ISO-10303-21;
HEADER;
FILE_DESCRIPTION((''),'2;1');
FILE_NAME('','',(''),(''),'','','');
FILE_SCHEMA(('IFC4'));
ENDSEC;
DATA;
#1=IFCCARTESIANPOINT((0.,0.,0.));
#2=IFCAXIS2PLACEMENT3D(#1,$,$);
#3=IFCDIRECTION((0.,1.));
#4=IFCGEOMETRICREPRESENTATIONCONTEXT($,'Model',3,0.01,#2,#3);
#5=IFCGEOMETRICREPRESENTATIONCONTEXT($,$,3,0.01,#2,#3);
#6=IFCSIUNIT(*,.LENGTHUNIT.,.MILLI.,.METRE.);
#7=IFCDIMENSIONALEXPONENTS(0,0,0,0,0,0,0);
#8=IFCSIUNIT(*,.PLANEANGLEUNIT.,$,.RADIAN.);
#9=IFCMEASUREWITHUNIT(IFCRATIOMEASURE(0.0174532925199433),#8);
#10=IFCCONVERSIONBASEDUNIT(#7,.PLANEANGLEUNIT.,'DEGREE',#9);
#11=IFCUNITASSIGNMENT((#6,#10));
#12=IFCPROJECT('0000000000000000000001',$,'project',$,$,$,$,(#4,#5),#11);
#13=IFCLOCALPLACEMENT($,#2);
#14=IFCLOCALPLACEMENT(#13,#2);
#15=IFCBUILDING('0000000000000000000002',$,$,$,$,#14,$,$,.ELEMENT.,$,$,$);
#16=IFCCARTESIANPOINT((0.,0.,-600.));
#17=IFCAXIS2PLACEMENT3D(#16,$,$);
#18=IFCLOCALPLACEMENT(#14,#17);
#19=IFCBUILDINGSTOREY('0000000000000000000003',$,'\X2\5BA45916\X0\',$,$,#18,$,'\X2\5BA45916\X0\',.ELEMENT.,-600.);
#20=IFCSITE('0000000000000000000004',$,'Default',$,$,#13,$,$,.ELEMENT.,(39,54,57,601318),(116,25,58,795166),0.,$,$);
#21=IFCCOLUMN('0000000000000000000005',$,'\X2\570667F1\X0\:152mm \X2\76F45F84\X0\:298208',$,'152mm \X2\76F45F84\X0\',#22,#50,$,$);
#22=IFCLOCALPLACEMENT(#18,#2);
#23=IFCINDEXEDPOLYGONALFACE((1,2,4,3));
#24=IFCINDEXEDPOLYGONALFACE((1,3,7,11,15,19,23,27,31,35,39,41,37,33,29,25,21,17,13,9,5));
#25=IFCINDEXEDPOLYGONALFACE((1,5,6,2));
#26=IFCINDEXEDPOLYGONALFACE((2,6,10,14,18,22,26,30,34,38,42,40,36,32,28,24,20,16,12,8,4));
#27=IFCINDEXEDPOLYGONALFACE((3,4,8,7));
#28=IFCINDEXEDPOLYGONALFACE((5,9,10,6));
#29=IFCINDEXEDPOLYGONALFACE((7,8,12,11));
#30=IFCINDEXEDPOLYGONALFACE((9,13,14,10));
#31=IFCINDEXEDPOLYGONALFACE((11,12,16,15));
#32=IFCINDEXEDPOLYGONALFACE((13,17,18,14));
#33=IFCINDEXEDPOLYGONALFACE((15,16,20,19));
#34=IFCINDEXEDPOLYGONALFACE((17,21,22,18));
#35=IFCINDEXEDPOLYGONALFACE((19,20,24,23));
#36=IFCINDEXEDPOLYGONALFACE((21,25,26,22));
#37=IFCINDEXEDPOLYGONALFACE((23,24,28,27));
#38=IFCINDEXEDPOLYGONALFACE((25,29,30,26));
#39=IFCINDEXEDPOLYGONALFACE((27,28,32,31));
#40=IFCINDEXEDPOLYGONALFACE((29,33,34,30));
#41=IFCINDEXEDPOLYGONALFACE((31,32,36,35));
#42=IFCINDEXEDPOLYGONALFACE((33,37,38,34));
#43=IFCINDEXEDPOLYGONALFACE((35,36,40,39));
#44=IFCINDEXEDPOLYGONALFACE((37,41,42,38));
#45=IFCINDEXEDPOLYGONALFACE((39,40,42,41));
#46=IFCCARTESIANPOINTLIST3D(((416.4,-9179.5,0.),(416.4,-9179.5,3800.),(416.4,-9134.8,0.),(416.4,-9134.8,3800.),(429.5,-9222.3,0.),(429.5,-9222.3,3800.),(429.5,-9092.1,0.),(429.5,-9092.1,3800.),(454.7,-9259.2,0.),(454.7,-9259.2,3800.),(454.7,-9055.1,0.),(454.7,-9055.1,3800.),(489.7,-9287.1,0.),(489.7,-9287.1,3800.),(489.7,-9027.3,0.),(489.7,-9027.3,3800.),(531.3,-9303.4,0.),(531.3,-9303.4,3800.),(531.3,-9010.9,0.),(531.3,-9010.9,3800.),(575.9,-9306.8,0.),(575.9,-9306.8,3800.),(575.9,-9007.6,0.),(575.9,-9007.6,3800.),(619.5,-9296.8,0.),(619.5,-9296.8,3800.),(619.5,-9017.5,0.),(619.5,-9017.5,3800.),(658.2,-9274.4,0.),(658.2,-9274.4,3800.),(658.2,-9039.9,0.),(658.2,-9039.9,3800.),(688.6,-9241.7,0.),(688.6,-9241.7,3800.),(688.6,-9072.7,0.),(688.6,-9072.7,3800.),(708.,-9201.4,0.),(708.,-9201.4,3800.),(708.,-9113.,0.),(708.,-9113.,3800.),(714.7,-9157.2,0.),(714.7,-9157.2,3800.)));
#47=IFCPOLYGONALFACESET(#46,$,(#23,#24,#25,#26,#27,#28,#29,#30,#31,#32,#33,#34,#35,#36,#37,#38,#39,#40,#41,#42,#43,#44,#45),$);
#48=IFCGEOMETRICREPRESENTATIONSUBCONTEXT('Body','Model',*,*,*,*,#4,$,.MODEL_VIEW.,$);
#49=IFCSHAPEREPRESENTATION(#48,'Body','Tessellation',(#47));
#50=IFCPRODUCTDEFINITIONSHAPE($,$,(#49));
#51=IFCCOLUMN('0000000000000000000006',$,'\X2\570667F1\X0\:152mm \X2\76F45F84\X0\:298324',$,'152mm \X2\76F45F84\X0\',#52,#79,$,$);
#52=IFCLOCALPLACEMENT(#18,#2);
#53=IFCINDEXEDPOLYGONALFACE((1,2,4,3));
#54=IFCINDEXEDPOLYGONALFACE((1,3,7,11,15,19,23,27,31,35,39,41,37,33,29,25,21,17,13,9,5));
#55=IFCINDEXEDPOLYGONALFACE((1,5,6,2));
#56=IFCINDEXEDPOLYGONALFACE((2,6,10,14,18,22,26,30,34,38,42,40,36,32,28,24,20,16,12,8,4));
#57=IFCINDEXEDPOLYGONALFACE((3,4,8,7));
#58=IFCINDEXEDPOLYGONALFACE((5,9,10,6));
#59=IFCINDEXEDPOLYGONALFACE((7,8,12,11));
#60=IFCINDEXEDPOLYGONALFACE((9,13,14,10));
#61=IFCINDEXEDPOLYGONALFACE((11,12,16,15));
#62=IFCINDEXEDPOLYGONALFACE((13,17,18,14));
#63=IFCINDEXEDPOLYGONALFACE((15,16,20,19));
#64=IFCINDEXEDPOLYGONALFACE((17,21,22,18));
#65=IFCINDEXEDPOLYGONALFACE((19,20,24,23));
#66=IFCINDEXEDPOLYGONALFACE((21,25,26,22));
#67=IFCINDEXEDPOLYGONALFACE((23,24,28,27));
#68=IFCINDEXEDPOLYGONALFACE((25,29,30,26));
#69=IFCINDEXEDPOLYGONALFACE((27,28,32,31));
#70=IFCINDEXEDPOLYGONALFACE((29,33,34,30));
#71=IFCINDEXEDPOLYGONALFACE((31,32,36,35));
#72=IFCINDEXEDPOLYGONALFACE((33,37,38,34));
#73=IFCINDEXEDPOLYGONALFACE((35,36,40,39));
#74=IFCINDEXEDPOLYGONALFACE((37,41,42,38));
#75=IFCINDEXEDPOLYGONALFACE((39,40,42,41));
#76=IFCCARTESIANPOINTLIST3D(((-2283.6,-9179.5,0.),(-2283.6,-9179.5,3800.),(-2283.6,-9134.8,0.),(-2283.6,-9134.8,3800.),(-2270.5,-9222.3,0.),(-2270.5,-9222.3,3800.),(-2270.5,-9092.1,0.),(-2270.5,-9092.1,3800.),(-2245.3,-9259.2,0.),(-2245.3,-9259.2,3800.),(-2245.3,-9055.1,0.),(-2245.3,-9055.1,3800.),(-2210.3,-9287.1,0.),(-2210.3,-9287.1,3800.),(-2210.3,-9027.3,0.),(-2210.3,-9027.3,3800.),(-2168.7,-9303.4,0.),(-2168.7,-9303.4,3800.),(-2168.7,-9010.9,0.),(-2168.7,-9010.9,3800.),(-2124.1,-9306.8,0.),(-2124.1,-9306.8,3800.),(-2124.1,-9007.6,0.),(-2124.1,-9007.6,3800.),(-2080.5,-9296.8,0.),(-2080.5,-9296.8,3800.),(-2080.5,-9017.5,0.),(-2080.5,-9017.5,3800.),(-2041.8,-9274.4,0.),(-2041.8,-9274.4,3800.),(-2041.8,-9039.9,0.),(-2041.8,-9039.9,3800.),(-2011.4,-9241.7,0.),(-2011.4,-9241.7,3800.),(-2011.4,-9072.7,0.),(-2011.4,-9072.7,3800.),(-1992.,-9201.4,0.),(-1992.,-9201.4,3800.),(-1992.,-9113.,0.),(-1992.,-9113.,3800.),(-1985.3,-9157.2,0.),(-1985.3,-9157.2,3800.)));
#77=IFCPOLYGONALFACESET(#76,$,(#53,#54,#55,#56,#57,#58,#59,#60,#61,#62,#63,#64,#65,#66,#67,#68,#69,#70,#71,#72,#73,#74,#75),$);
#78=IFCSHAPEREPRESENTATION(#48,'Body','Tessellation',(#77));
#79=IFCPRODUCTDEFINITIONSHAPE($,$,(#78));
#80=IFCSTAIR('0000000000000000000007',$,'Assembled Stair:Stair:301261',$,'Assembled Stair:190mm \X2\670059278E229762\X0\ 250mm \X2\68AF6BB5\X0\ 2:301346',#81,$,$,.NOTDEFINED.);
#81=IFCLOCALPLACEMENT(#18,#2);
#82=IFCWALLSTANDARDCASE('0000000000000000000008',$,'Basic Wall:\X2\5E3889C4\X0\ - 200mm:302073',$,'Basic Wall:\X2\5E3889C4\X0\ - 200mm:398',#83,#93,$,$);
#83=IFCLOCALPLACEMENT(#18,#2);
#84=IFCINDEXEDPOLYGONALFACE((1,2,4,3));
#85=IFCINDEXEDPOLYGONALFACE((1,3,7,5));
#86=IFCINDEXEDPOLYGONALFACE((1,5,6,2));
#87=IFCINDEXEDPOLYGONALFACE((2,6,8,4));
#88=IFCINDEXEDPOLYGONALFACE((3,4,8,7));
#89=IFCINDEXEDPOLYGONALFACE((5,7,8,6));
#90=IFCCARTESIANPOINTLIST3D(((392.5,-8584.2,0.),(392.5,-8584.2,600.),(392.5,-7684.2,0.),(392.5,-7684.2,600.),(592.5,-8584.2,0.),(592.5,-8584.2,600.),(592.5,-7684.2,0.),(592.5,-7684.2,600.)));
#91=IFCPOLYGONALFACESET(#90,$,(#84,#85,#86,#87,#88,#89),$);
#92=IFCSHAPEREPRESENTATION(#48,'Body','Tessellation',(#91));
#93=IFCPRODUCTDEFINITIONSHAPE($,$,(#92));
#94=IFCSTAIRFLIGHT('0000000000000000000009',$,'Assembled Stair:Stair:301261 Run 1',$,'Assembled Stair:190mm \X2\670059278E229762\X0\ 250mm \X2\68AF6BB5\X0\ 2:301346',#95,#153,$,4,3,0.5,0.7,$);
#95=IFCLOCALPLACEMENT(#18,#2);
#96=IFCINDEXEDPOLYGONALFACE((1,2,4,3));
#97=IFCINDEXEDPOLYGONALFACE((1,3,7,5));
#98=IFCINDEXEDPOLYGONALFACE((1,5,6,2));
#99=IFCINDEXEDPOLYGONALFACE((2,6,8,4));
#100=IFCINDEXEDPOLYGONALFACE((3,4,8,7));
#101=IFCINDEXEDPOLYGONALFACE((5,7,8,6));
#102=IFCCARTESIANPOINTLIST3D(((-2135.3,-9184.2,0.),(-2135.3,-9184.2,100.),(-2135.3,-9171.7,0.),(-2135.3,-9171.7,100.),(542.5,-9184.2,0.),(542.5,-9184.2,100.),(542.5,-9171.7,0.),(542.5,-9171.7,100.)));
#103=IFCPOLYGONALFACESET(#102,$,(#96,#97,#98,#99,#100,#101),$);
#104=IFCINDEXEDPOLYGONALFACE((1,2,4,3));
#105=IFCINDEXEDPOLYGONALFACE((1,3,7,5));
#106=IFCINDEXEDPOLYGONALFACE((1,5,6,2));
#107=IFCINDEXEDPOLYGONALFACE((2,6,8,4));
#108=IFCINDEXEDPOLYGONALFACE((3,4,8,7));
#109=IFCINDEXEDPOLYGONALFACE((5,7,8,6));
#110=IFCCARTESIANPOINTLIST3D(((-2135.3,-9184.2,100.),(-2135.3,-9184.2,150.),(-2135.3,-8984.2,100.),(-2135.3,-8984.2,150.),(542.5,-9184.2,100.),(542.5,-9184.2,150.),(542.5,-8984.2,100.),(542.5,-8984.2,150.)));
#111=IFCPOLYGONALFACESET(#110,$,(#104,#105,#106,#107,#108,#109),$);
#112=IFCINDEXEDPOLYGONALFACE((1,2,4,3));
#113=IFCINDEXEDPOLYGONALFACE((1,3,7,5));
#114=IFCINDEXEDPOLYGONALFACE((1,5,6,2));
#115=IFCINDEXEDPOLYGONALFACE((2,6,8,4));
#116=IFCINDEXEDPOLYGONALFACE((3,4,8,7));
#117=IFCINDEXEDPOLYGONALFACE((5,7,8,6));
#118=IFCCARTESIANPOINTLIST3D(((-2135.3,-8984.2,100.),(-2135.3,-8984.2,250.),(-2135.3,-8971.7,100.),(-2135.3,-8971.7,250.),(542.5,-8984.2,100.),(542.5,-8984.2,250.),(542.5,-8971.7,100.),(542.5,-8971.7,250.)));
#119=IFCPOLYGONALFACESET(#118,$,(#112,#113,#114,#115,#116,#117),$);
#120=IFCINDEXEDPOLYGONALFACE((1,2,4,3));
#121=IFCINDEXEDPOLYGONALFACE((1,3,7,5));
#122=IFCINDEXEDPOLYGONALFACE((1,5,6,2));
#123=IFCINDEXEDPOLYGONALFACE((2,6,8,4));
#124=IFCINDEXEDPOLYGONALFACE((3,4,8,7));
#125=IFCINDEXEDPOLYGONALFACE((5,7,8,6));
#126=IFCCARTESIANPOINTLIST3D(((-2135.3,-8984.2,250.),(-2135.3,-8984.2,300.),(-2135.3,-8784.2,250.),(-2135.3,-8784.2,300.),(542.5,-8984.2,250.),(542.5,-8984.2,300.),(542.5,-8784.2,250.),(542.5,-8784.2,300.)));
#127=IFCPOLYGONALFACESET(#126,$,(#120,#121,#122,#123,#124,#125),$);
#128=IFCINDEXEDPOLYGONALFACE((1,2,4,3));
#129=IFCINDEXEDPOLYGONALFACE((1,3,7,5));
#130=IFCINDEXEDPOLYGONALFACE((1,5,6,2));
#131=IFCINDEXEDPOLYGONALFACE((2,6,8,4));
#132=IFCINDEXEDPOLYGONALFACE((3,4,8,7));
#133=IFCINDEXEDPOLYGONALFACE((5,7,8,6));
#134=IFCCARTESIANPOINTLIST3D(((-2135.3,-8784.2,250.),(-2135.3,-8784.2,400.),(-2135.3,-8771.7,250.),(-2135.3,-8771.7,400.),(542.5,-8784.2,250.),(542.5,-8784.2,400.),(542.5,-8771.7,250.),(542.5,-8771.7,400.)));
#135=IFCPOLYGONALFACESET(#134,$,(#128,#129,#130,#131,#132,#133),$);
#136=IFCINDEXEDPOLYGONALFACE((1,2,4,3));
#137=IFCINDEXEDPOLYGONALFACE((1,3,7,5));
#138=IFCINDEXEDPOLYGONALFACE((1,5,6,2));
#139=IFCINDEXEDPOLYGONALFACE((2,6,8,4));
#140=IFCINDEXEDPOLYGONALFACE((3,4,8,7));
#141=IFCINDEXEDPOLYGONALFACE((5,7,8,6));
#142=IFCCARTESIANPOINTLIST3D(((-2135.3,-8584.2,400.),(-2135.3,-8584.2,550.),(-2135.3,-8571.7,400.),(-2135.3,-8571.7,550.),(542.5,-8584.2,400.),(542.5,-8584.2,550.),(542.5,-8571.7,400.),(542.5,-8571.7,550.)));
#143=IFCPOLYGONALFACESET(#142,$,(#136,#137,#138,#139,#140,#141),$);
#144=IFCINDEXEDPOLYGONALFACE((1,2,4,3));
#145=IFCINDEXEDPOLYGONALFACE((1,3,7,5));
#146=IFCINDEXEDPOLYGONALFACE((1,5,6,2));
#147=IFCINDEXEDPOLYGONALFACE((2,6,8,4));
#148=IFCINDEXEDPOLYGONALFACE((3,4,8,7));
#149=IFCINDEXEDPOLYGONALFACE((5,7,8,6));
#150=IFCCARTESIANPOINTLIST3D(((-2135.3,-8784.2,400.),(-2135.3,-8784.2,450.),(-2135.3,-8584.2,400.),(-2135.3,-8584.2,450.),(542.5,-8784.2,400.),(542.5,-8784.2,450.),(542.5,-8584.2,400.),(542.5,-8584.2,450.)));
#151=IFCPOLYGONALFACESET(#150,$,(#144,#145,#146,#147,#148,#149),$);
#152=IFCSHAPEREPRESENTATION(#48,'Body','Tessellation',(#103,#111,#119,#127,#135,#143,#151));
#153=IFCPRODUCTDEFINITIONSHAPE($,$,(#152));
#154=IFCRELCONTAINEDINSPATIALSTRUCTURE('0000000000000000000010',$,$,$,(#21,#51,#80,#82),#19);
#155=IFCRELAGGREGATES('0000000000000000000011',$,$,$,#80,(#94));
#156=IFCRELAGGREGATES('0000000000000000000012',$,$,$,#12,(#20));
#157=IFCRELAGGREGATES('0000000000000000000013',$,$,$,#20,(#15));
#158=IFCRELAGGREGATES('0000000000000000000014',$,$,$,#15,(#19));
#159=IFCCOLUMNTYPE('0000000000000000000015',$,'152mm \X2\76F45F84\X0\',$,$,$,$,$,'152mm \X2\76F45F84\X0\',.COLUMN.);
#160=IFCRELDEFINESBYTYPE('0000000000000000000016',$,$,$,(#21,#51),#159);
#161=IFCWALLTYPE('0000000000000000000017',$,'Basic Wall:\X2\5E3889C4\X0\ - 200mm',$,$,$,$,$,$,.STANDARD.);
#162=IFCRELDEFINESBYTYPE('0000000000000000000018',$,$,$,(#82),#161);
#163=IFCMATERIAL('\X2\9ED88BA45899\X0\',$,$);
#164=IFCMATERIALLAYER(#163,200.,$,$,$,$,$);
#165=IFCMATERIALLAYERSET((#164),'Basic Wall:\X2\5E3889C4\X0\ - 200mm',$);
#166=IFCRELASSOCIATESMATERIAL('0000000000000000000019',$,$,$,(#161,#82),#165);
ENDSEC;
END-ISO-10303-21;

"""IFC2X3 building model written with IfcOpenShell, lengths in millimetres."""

from ifc_helpers import new_model, entity, si_unit, converted_unit, direction, frame, frame_2d, origin, origin_2d_with_axis, place, context, subcontext, project, spatial, rectangle, circle, extrude, source, transform, mapped, material, layer, layer_set, layer_usage, type_object, type_shapes, element, aggregate, save


model = new_model("IFC2X3")

# Units and contexts
model_context = context("Model", 3, precision=0.01, world=origin(), true_north=direction((0.0, 1.0)))
context_of_model = context(None, 3, precision=0.01, world=origin(), true_north=direction((0.0, 1.0)))
body_context = subcontext(model_context, "Body", "Model", "MODEL_VIEW")
ifc_project = project(units=[si_unit("LENGTHUNIT", "METRE", prefix="MILLI"), converted_unit("PLANEANGLEUNIT", "DEGREE", entity("IfcRatioMeasure", 0.0174532925199433), si_unit("PLANEANGLEUNIT", "RADIAN"), dimensions=[0, 0, 0, 0, 0, 0, 0])], contexts=[model_context, context_of_model])

# Site, building, storey
site_placement = place(None, origin())
site = spatial("IfcSite", under=ifc_project, at=site_placement, Name="Default", CompositionType="ELEMENT", RefLatitude=(39, 54, 57, 601318), RefLongitude=(116, 25, 58, 795166), RefElevation=0.0)
building_placement = place(site_placement, origin())
building = spatial("IfcBuilding", under=site, at=building_placement, CompositionType="ELEMENT")
storey_placement = place(building_placement, frame((0.0, 0.0, -600.0)))
storey = spatial("IfcBuildingStorey", under=building, at=storey_placement, Name="室外", LongName="室外", CompositionType="ELEMENT", Elevation=-600.0)

# Columns
column_type = type_object("IfcColumnType", Name="152mm 直径", ElementType="152mm 直径", PredefinedType="COLUMN")
shared_shape = source(origin(), body_context, "Body", "SweptSolid", [
    extrude(circle(Radius=150.0, at=frame_2d((0.0, -50.0), x_axis=(1.0, 0.0))), frame((0.0, 50.0, -600.0)), (0.0, 0.0, 1.0), 3800.0),
])
type_shapes(column_type, [shared_shape])
for number, where, name in (
    (1, (564.7, -9157.2, 600.0), "圆柱:152mm 直径:298208"),
    (2, (-2135.3, -9157.2, 600.0), "圆柱:152mm 直径:298324"),
):
    element("IfcColumn", number, at=place(storey_placement, frame(where)), inside=storey, type_object=column_type, Name=name, ObjectType="152mm 直径", context=body_context, shape_type="MappedRepresentation", body=[
        mapped(shared_shape, transform((0.0, 0.0, 0.0), scale=1.0)),
    ])

# Stair
stair_placement = place(storey_placement, origin())
stair = element("IfcStair", 3, at=stair_placement, inside=storey, Name="Assembled Stair:Stair:301261", ObjectType="Assembled Stair:190mm 最大踢面 250mm 梯段 2:301346", ShapeType="NOTDEFINED")

# Wall
ifc_material = material(Name="默认墙")
ifc_layer = layer(ifc_material, 200.0)
ifc_layer_set = layer_set([ifc_layer], Name="Basic Wall:常规 - 200mm")
ifc_layer_usage = layer_usage(ifc_layer_set, "AXIS2", "NEGATIVE", 100.0)
wall_type = type_object("IfcWallType", Name="Basic Wall:常规 - 200mm", PredefinedType="STANDARD", material=ifc_layer_set)
wall_placement = place(storey_placement, frame((492.5, -7684.2, 0.0), z_axis=(0.0, 0.0, 1.0), x_axis=(0.0, -1.0, 0.0)))
element("IfcWallStandardCase", 4, at=wall_placement, inside=storey, type_object=wall_type, material=ifc_layer_usage, Name="Basic Wall:常规 - 200mm:302073", ObjectType="Basic Wall:常规 - 200mm:398", context=body_context, shape_type="SweptSolid", body=[
    extrude(rectangle(XDim=900.0, YDim=200.0, at=frame_2d((450.0, 0.0), x_axis=(-1.0, 0.0))), origin(), (0.0, 0.0, 1.0), 600.0),
])

# Stair flight
stair_flight_placement = place(stair_placement, origin())
stair_flight = element("IfcStairFlight", 5, at=stair_flight_placement, Name="Assembled Stair:Stair:301261 Run 1", ObjectType="Assembled Stair:190mm 最大踢面 250mm 梯段 2:301346", NumberOfRiser=4, NumberOfTreads=3, RiserHeight=0.5, TreadLength=0.7, context=body_context, shape_type="SweptSolid", body=[
    extrude(rectangle(XDim=2677.8, YDim=12.5, at=origin_2d_with_axis()), frame((-796.4, -9177.9, 0.0), z_axis=(0.0, 0.0, 1.0), x_axis=(-1.0, 0.0, 0.0)), (0.0, 0.0, 1.0), 100.0),
    extrude(rectangle(XDim=200.0, YDim=2677.8, at=frame_2d((0.0, 0.0), x_axis=(1.0, 0.0))), frame((-796.4, -9084.2, 100.0), z_axis=(0.0, 0.0, 1.0), x_axis=(0.0, -1.0, 0.0)), (0.0, 0.0, 1.0), 50.0),
    extrude(rectangle(XDim=2677.8, YDim=12.5, at=origin_2d_with_axis()), frame((-796.4, -8977.9, 100.0), z_axis=(0.0, 0.0, 1.0), x_axis=(-1.0, 0.0, 0.0)), (0.0, 0.0, 1.0), 150.0),
    extrude(rectangle(XDim=200.0, YDim=2677.8, at=frame_2d((0.0, 0.0), x_axis=(1.0, 0.0))), frame((-796.4, -8884.2, 250.0), z_axis=(0.0, 0.0, 1.0), x_axis=(0.0, -1.0, 0.0)), (0.0, 0.0, 1.0), 50.0),
    extrude(rectangle(XDim=2677.8, YDim=12.5, at=origin_2d_with_axis()), frame((-796.4, -8777.9, 250.0), z_axis=(0.0, 0.0, 1.0), x_axis=(-1.0, 0.0, 0.0)), (0.0, 0.0, 1.0), 150.0),
    extrude(rectangle(XDim=2677.8, YDim=12.5, at=origin_2d_with_axis()), frame((-796.4, -8577.9, 400.0), z_axis=(0.0, 0.0, 1.0), x_axis=(-1.0, 0.0, 0.0)), (0.0, 0.0, 1.0), 150.0),
    extrude(rectangle(XDim=200.0, YDim=2677.8, at=frame_2d((0.0, 0.0), x_axis=(1.0, 0.0))), frame((-796.4, -8684.2, 400.0), z_axis=(0.0, 0.0, 1.0), x_axis=(0.0, -1.0, 0.0)), (0.0, 0.0, 1.0), 50.0),
])
aggregate(stair, [stair_flight])

save(model, "model.ifc")
